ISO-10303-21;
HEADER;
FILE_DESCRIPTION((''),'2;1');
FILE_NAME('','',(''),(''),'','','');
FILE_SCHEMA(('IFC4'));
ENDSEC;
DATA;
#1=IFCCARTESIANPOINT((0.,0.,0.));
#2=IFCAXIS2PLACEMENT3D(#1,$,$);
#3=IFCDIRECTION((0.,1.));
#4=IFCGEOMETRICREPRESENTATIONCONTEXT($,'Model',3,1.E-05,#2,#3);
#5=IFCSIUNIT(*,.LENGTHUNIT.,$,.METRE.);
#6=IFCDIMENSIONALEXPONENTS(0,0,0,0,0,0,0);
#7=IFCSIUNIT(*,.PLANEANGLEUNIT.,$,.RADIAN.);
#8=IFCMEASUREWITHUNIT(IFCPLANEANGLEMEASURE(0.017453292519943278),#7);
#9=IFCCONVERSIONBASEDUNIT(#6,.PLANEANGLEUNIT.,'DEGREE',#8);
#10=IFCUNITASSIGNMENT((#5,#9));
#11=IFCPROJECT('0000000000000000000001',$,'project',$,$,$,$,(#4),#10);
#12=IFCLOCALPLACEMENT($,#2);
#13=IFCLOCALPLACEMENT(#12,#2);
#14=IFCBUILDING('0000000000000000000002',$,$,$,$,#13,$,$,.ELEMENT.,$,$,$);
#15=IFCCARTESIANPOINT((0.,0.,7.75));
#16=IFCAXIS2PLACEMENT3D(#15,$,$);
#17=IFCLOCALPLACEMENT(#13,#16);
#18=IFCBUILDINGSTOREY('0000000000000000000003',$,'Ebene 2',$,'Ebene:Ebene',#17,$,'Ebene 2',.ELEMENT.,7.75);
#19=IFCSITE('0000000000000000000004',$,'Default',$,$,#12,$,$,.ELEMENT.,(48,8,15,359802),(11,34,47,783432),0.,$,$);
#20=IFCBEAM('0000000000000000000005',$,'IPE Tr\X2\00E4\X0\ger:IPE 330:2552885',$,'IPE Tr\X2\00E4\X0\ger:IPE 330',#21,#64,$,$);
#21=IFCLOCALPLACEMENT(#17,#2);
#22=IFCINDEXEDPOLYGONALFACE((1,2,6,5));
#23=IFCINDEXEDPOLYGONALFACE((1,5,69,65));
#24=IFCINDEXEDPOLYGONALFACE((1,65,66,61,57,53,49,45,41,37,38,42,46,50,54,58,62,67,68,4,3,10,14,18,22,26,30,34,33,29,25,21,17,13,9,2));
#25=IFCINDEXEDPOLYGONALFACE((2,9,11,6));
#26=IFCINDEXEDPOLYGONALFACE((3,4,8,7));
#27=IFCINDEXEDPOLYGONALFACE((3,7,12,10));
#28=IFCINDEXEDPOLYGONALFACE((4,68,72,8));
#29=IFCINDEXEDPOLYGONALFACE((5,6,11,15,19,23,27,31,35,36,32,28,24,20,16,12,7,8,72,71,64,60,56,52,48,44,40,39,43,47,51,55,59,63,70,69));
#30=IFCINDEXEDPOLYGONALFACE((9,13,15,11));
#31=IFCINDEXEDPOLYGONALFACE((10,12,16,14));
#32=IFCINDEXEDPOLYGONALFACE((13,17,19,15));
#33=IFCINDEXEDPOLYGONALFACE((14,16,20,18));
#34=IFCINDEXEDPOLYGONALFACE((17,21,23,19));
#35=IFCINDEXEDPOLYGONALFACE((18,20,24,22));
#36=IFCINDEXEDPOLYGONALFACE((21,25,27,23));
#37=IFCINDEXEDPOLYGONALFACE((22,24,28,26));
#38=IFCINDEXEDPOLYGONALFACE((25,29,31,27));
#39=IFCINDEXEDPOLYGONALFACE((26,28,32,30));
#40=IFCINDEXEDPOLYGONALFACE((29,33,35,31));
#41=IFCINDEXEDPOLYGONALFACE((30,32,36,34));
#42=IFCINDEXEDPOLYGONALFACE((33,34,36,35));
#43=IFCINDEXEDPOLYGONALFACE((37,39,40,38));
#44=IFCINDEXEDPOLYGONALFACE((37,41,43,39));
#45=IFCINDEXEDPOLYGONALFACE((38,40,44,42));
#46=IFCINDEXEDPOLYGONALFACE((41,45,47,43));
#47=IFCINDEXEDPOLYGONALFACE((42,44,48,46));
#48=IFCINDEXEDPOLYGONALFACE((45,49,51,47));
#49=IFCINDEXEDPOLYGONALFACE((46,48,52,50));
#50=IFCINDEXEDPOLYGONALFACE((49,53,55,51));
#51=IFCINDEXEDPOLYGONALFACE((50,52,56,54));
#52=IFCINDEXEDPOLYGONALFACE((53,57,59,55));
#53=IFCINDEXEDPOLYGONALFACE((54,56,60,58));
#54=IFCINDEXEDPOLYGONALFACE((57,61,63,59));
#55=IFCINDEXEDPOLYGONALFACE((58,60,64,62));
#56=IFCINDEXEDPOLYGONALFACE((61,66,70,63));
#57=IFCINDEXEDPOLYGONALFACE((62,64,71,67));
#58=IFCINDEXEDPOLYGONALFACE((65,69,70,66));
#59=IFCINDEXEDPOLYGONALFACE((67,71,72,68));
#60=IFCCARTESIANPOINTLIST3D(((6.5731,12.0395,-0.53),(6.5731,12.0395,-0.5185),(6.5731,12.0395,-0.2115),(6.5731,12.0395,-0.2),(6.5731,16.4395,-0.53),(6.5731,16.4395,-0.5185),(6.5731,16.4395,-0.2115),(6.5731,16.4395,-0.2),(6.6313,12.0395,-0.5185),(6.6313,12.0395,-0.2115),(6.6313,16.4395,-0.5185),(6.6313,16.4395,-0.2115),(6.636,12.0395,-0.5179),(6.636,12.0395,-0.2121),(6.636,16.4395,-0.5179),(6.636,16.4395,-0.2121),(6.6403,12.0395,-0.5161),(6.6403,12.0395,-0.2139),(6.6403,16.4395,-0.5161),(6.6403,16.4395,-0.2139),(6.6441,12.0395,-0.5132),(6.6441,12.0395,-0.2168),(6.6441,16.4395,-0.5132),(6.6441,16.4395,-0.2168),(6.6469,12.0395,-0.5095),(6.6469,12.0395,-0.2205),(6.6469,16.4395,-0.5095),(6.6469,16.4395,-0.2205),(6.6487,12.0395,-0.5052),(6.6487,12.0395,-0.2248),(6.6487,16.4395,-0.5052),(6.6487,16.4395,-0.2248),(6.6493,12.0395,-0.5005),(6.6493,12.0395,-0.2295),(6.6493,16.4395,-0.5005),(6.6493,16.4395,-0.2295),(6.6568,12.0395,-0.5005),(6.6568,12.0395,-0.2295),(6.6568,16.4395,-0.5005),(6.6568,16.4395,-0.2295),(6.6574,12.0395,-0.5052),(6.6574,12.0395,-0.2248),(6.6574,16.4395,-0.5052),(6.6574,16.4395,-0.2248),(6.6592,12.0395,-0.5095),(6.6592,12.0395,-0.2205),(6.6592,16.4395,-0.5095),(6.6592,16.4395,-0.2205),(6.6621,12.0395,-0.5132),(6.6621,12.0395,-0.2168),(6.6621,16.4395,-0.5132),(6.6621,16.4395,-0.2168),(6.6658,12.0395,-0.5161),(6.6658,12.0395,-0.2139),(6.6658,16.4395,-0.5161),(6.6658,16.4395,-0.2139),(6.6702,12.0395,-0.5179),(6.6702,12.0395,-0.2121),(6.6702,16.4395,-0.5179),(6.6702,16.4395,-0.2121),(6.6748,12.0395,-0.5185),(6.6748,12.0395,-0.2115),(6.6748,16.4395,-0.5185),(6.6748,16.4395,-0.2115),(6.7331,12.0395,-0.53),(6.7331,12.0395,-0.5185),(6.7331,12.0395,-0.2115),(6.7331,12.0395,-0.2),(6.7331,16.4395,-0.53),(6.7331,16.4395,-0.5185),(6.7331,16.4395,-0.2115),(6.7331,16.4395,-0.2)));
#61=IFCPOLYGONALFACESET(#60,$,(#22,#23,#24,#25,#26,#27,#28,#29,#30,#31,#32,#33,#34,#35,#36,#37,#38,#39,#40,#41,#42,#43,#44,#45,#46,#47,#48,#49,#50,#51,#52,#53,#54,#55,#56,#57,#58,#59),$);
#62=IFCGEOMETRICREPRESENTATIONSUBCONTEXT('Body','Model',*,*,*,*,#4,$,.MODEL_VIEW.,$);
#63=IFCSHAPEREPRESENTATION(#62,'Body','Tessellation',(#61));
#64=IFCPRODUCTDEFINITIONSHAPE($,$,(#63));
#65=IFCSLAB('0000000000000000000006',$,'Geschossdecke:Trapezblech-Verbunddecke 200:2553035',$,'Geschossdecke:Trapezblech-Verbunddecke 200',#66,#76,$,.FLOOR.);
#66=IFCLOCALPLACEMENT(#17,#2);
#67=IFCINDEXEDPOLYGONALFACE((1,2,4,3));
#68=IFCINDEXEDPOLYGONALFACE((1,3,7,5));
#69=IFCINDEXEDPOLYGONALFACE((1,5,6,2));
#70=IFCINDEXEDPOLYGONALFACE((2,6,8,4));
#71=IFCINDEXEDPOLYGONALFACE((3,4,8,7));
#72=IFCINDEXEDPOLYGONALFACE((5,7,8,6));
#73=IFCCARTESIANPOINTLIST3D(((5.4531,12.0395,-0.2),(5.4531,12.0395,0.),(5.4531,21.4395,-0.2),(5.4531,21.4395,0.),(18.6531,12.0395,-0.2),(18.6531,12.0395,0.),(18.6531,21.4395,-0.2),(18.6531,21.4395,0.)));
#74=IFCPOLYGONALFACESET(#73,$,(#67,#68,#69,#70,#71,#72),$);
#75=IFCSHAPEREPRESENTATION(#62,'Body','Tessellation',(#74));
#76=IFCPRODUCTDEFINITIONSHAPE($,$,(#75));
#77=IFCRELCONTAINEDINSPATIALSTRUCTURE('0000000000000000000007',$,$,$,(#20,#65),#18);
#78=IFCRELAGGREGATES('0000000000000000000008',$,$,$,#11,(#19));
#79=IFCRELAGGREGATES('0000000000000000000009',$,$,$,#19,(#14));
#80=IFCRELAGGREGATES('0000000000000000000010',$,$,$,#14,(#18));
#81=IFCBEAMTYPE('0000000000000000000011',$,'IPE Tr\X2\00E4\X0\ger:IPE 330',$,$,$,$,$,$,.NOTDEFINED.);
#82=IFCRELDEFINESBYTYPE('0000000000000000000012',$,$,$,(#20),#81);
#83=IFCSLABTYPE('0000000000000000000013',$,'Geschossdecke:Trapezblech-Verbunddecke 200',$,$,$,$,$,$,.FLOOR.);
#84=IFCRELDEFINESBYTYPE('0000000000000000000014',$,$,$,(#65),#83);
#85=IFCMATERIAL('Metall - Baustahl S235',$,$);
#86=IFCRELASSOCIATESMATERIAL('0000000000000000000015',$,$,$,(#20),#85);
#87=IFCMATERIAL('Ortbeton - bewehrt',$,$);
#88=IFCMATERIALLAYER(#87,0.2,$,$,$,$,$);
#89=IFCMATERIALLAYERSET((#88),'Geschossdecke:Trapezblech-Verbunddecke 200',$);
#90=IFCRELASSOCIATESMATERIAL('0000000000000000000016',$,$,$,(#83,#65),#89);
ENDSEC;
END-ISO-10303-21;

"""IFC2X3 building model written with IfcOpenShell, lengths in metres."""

from ifc_helpers import new_model, entity, si_unit, converted_unit, direction, frame, frame_2d, origin, origin_2d_with_axis, place, context, subcontext, project, spatial, rectangle, i_section, extrude, material, layer, layer_set, layer_usage, type_object, element, save


model = new_model("IFC2X3")

# Units and contexts
model_context = context("Model", 3, precision=1e-05, world=origin(), true_north=direction((0.0, 1.0)))
body_context = subcontext(model_context, "Body", "Model", "MODEL_VIEW")
ifc_project = project(units=[si_unit("LENGTHUNIT", "METRE"), converted_unit("PLANEANGLEUNIT", "DEGREE", entity("IfcPlaneAngleMeasure", 0.017453292519943278), si_unit("PLANEANGLEUNIT", "RADIAN"), dimensions=[0, 0, 0, 0, 0, 0, 0])], contexts=[model_context])

# Site, building, storey
site_placement = place(None, origin())
site = spatial("IfcSite", under=ifc_project, at=site_placement, Name="Default", CompositionType="ELEMENT", RefLatitude=(48, 8, 15, 359802), RefLongitude=(11, 34, 47, 783432), RefElevation=0.0)
building_placement = place(site_placement, origin())
building = spatial("IfcBuilding", under=site, at=building_placement, CompositionType="ELEMENT")
storey_placement = place(building_placement, frame((0.0, 0.0, 7.75)))
storey = spatial("IfcBuildingStorey", under=building, at=storey_placement, Name="Ebene 2", ObjectType="Ebene:Ebene", LongName="Ebene 2", CompositionType="ELEMENT", Elevation=7.75)

# Beam
ifc_material_1 = material(Name="Metall - Baustahl S235")
beam_type = type_object("IfcBeamType", Name="IPE Träger:IPE 330", PredefinedType="NOTDEFINED")
beam_1_placement = place(storey_placement, frame((6.6531, 12.0395, -0.2), z_axis=(0.0, 0.0, 1.0), x_axis=(0.0, 1.0, 0.0)))
element("IfcBeam", 1, at=beam_1_placement, inside=storey, type_object=beam_type, material=ifc_material_1, Name="IPE Träger:IPE 330:2552885", ObjectType="IPE Träger:IPE 330", context=body_context, shape_type="SweptSolid", body=[
    extrude(i_section(OverallWidth=0.16, OverallDepth=0.33, WebThickness=0.0075, FlangeThickness=0.0115, FilletRadius=0.018, at=frame_2d((0.0, 0.0), x_axis=(0.0, 1.0))), frame((0.0, 0.0, -0.165), z_axis=(1.0, 0.0, 0.0), x_axis=(0.0, 0.0, -1.0)), (0.0, 0.0, 1.0), 4.4),
])

# Slab
ifc_material_2 = material(Name="Ortbeton - bewehrt")
ifc_layer = layer(ifc_material_2, 0.2)
ifc_layer_set = layer_set([ifc_layer], Name="Geschossdecke:Trapezblech-Verbunddecke 200")
ifc_layer_usage = layer_usage(ifc_layer_set, "AXIS3", "POSITIVE", 0.0)
slab_type = type_object("IfcSlabType", Name="Geschossdecke:Trapezblech-Verbunddecke 200", PredefinedType="FLOOR", material=ifc_layer_set)
slab_placement = place(storey_placement, origin())
element("IfcSlab", 2, at=slab_placement, inside=storey, type_object=slab_type, material=ifc_layer_usage, Name="Geschossdecke:Trapezblech-Verbunddecke 200:2553035", ObjectType="Geschossdecke:Trapezblech-Verbunddecke 200", PredefinedType="FLOOR", context=body_context, shape_type="SweptSolid", body=[
    extrude(rectangle(XDim=9.4, YDim=13.2, at=origin_2d_with_axis()), frame((12.0531, 16.7395, 0.0), z_axis=(0.0, 0.0, -1.0), x_axis=(0.0, 1.0, 0.0)), (0.0, 0.0, 1.0), 0.2),
])

save(model, "model.ifc")
